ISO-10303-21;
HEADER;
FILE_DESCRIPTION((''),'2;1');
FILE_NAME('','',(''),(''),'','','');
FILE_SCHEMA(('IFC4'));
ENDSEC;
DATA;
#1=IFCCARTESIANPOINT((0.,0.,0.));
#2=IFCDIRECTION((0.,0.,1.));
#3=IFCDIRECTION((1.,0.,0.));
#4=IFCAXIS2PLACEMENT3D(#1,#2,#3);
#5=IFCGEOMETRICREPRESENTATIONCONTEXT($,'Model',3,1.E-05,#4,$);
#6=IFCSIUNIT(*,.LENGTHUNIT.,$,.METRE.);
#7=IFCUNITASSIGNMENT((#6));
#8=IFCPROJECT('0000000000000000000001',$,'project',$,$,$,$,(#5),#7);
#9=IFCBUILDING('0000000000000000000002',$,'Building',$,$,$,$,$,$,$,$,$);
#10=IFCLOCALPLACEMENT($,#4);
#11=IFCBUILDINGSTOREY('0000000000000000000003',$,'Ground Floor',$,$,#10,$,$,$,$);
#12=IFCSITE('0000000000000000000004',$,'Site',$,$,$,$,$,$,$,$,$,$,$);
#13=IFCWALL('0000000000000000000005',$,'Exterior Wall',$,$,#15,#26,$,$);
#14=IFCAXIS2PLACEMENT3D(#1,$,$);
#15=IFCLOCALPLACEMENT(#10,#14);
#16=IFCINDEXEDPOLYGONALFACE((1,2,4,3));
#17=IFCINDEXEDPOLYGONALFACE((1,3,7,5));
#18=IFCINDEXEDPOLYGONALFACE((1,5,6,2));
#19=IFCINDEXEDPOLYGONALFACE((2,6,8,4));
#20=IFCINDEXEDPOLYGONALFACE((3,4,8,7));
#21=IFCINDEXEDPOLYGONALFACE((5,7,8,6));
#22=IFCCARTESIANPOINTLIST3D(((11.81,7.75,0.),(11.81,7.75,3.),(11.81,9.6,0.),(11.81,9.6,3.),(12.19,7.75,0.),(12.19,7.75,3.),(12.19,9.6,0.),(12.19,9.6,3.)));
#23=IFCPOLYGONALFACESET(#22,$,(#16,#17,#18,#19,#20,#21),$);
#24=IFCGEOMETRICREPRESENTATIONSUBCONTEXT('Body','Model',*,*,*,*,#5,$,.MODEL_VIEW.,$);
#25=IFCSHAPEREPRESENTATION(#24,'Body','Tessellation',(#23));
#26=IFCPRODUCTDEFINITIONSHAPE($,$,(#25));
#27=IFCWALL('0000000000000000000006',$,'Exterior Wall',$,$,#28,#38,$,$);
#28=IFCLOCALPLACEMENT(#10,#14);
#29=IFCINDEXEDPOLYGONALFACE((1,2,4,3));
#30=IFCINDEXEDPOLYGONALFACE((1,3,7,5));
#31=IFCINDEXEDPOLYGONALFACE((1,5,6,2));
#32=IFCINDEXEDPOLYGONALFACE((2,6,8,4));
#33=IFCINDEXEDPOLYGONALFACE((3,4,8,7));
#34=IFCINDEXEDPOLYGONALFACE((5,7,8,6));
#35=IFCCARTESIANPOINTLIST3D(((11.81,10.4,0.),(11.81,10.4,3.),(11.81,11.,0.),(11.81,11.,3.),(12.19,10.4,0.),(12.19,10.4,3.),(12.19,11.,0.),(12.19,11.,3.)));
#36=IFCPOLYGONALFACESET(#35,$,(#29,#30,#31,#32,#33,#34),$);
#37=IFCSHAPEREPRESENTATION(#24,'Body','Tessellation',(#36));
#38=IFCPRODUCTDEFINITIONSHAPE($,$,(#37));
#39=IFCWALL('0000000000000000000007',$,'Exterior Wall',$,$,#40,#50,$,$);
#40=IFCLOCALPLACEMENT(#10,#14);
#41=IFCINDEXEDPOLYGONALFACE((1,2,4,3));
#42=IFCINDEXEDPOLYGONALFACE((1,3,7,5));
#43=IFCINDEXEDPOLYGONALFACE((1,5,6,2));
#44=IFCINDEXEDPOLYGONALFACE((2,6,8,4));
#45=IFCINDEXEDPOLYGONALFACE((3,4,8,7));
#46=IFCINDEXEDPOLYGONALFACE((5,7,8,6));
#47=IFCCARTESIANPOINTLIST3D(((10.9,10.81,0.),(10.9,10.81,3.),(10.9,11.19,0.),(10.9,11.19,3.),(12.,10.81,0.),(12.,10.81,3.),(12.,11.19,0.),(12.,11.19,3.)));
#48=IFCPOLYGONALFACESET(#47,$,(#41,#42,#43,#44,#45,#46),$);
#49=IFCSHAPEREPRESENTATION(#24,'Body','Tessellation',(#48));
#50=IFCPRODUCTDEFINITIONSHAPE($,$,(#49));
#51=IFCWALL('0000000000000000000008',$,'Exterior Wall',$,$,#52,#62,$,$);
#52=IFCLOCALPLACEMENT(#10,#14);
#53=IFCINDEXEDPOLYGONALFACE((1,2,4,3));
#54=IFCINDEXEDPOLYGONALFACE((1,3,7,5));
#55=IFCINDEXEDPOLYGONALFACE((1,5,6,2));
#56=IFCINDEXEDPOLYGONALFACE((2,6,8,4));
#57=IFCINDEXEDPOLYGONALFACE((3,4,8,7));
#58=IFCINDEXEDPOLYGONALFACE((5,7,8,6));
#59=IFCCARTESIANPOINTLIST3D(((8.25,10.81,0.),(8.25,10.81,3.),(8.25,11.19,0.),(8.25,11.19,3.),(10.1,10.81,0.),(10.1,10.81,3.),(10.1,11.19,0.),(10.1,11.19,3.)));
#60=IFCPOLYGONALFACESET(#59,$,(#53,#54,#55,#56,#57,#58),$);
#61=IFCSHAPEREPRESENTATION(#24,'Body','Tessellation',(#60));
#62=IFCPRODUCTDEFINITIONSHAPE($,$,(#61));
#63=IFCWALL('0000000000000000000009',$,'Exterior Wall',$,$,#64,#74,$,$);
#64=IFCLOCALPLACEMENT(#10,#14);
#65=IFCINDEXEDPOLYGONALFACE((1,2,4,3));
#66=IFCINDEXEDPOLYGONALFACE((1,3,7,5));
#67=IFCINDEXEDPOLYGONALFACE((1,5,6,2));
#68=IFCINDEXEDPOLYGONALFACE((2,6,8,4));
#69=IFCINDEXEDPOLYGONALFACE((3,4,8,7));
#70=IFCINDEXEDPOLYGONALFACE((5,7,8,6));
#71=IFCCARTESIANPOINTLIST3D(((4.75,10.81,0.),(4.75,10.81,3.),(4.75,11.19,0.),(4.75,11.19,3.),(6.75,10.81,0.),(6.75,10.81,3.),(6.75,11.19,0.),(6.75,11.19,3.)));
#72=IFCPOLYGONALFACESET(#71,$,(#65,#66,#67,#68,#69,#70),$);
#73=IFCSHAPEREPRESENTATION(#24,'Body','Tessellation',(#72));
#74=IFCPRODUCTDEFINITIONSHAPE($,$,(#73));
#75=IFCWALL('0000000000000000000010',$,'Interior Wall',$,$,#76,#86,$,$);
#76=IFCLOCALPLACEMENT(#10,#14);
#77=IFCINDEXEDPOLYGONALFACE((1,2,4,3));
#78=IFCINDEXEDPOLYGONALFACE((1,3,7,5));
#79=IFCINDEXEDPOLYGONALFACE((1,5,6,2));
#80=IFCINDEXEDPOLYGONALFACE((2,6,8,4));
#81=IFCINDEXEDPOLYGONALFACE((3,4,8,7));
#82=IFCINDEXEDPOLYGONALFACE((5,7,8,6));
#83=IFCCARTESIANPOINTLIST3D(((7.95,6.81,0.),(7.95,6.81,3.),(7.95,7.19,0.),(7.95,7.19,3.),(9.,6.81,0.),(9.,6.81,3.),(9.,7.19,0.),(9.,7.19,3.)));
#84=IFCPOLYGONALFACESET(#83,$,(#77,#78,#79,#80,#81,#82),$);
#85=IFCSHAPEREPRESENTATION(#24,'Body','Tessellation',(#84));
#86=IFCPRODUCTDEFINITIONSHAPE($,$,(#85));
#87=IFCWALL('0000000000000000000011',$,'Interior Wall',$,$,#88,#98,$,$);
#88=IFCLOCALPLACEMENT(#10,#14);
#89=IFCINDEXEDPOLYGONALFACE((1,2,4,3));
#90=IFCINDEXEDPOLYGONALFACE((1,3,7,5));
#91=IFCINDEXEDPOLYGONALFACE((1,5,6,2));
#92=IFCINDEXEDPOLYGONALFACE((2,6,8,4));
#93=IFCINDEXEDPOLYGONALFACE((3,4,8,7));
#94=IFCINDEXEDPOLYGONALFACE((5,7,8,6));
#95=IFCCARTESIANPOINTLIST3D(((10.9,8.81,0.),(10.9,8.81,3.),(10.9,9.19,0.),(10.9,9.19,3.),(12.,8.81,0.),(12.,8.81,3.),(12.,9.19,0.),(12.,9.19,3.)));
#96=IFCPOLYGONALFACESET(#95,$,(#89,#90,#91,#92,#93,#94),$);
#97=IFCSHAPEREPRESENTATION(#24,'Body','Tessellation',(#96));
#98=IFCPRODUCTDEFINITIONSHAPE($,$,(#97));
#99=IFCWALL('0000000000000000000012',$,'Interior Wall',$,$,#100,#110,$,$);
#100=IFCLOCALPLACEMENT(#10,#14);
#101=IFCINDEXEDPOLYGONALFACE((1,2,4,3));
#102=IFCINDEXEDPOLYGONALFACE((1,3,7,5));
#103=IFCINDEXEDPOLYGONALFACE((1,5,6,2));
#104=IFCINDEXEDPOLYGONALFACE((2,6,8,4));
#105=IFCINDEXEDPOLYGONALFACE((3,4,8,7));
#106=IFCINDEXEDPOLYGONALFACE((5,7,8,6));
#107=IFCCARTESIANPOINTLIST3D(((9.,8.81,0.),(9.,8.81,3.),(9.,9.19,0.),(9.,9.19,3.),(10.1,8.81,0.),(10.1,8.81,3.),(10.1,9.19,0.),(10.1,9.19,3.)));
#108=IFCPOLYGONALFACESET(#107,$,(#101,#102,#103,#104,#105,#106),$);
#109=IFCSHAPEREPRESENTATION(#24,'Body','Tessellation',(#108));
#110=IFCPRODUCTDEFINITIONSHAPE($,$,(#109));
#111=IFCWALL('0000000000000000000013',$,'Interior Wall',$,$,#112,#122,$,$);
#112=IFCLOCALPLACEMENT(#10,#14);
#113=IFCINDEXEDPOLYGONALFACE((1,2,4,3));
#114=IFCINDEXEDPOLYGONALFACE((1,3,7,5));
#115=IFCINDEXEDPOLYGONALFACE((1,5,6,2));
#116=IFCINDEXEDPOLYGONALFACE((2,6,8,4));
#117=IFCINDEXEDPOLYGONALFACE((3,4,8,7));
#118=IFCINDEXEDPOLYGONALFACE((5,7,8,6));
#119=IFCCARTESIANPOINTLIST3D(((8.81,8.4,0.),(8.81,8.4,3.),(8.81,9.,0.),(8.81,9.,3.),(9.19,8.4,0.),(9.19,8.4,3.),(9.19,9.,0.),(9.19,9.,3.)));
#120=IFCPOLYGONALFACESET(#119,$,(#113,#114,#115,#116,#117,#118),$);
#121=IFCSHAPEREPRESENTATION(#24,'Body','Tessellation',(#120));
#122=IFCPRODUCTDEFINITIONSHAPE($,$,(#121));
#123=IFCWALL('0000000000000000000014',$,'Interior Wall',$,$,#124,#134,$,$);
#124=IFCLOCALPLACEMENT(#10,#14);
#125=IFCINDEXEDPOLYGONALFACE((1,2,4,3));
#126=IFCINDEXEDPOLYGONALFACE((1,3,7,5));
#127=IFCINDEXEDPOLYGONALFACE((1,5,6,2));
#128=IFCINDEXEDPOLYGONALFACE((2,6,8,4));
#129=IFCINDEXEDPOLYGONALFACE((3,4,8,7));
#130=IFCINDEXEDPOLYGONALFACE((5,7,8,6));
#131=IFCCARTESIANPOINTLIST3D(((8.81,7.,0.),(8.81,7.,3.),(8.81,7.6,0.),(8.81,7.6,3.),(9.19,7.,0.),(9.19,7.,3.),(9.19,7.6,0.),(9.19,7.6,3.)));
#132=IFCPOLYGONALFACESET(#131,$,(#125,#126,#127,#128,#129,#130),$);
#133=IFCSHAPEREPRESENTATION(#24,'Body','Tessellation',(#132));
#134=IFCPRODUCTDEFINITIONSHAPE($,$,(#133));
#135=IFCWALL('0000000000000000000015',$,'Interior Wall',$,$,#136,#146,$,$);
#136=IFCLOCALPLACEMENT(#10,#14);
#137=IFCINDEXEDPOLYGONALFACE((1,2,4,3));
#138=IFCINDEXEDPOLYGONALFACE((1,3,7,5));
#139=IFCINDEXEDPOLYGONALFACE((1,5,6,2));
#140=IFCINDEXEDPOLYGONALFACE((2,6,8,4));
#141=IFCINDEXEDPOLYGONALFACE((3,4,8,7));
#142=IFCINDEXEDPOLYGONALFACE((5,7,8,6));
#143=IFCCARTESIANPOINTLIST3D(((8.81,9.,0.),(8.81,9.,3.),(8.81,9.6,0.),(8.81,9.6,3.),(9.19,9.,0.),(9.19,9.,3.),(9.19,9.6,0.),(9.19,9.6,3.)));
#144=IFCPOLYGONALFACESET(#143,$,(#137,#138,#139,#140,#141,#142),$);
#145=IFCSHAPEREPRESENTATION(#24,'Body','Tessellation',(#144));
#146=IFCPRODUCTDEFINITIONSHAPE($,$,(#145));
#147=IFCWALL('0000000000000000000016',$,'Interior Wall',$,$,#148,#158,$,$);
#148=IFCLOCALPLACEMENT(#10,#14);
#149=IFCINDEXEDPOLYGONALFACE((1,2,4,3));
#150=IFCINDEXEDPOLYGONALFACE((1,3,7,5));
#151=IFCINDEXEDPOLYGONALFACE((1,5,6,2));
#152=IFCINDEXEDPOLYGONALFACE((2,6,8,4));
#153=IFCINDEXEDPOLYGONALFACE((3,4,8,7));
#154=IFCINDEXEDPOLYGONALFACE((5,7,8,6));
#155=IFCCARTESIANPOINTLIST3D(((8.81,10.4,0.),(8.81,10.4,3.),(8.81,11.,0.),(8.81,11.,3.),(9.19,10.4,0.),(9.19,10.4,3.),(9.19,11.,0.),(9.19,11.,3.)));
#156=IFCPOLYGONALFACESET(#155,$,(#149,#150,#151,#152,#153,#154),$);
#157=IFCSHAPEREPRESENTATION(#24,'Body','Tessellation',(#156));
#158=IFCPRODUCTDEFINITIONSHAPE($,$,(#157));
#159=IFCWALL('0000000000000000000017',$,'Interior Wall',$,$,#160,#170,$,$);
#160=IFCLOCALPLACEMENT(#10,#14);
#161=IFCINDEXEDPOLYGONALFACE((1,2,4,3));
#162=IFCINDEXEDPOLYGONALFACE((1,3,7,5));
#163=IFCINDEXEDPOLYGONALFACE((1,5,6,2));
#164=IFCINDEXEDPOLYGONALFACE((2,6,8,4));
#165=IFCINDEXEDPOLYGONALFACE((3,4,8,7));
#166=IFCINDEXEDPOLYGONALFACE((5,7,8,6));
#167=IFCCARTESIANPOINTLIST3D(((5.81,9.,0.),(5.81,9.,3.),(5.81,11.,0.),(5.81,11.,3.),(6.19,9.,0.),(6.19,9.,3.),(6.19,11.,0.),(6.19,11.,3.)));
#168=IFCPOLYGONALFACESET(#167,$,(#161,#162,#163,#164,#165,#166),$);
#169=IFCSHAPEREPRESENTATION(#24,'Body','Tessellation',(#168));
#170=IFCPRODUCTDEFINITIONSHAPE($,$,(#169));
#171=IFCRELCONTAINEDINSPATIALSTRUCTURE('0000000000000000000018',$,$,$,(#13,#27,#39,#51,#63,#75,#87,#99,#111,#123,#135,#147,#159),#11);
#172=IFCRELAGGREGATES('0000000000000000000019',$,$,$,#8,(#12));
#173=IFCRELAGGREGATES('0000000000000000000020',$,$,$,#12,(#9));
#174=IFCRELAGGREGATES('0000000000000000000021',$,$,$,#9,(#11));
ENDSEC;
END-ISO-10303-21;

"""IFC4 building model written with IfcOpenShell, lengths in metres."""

from ifc_helpers import new_model, si_unit, frame, origin_with_axes, place, context, subcontext, project, spatial, indexed_curve, outline, extrude, element, save


model = new_model("IFC4")

# Units and contexts
model_context = context("Model", 3, precision=1e-05, world=origin_with_axes())
body_context = subcontext(model_context, "Body", "Model", "MODEL_VIEW")
ifc_project = project(units=[si_unit("LENGTHUNIT", "METRE")], contexts=[model_context])

# Site, building, storey
site = spatial("IfcSite", under=ifc_project, Name="Site")
building = spatial("IfcBuilding", under=site, Name="Building")
storey_placement = place(None, origin_with_axes())
storey = spatial("IfcBuildingStorey", under=building, at=storey_placement, Name="Ground Floor")

# Walls
wall_1_placement = place(storey_placement, frame((12.0, 7.75, 0.0), z_axis=(0.0, 0.0, 1.0), x_axis=(0.0, 1.0, 0.0)))
element("IfcWall", 1, at=wall_1_placement, inside=storey, Name="Exterior Wall", context=body_context, shape_type="SweptSolid", body=[
    extrude(outline(indexed_curve([(0.0, 0.0), (0.0, 0.38), (1.85, 0.38), (1.85, 0.0), (0.0, 0.0)], self_intersect=False)), frame((0.0, -0.19, 0.0), z_axis=(0.0, 0.0, 1.0), x_axis=(1.0, 0.0, 0.0)), (0.0, 0.0, 1.0), 3.0),
])
wall_2_placement = place(storey_placement, frame((12.0, 10.4, 0.0), z_axis=(0.0, 0.0, 1.0), x_axis=(0.0, 1.0, 0.0)))
element("IfcWall", 2, at=wall_2_placement, inside=storey, Name="Exterior Wall", context=body_context, shape_type="SweptSolid", body=[
    extrude(outline(indexed_curve([(0.0, 0.0), (0.0, 0.38), (0.6, 0.38), (0.6, 0.0), (0.0, 0.0)], self_intersect=False)), frame((0.0, -0.19, 0.0), z_axis=(0.0, 0.0, 1.0), x_axis=(1.0, 0.0, 0.0)), (0.0, 0.0, 1.0), 3.0),
])
wall_3_placement = place(storey_placement, frame((12.0, 11.0, 0.0), z_axis=(0.0, 0.0, 1.0), x_axis=(-1.0, 0.0, 0.0)))
element("IfcWall", 3, at=wall_3_placement, inside=storey, Name="Exterior Wall", context=body_context, shape_type="SweptSolid", body=[
    extrude(outline(indexed_curve([(0.0, 0.0), (0.0, 0.38), (1.1, 0.38), (1.1, 0.0), (0.0, 0.0)], self_intersect=False)), frame((0.0, -0.19, 0.0), z_axis=(0.0, 0.0, 1.0), x_axis=(1.0, 0.0, 0.0)), (0.0, 0.0, 1.0), 3.0),
])
wall_4_placement = place(storey_placement, frame((10.1, 11.0, 0.0), z_axis=(0.0, 0.0, 1.0), x_axis=(-1.0, 0.0, 0.0)))
element("IfcWall", 4, at=wall_4_placement, inside=storey, Name="Exterior Wall", context=body_context, shape_type="SweptSolid", body=[
    extrude(outline(indexed_curve([(0.0, 0.0), (0.0, 0.38), (1.85, 0.38), (1.85, 0.0), (0.0, 0.0)], self_intersect=False)), frame((0.0, -0.19, 0.0), z_axis=(0.0, 0.0, 1.0), x_axis=(1.0, 0.0, 0.0)), (0.0, 0.0, 1.0), 3.0),
])
wall_5_placement = place(storey_placement, frame((6.75, 11.0, 0.0), z_axis=(0.0, 0.0, 1.0), x_axis=(-1.0, 0.0, 0.0)))
element("IfcWall", 5, at=wall_5_placement, inside=storey, Name="Exterior Wall", context=body_context, shape_type="SweptSolid", body=[
    extrude(outline(indexed_curve([(0.0, 0.0), (0.0, 0.38), (2.0, 0.38), (2.0, 0.0), (0.0, 0.0)], self_intersect=False)), frame((0.0, -0.19, 0.0), z_axis=(0.0, 0.0, 1.0), x_axis=(1.0, 0.0, 0.0)), (0.0, 0.0, 1.0), 3.0),
])
wall_6_placement = place(storey_placement, frame((9.0, 7.0, 0.0), z_axis=(0.0, 0.0, 1.0), x_axis=(-1.0, 0.0, 0.0)))
element("IfcWall", 6, at=wall_6_placement, inside=storey, Name="Interior Wall", context=body_context, shape_type="SweptSolid", body=[
    extrude(outline(indexed_curve([(0.0, 0.0), (0.0, 0.38), (1.05, 0.38), (1.05, 0.0), (0.0, 0.0)], self_intersect=False)), frame((0.0, -0.19, 0.0), z_axis=(0.0, 0.0, 1.0), x_axis=(1.0, 0.0, 0.0)), (0.0, 0.0, 1.0), 3.0),
])
for number, where, z_axis, x_axis, name in (
    (7, (12.0, 9.0, 0.0), (0.0, 0.0, 1.0), (-1.0, 0.0, 0.0), "Interior Wall"),
    (8, (10.1, 9.0, 0.0), (0.0, 0.0, 1.0), (-1.0, 0.0, 0.0), "Interior Wall"),
):
    element("IfcWall", number, at=place(storey_placement, frame(where, z_axis=z_axis, x_axis=x_axis)), inside=storey, Name=name, context=body_context, shape_type="SweptSolid", body=[
        extrude(outline(indexed_curve([(0.0, 0.0), (0.0, 0.38), (1.1, 0.38), (1.1, 0.0), (0.0, 0.0)], self_intersect=False)), frame((0.0, -0.19, 0.0), z_axis=(0.0, 0.0, 1.0), x_axis=(1.0, 0.0, 0.0)), (0.0, 0.0, 1.0), 3.0),
    ])
for number, where, z_axis, x_axis, name in (
    (9, (9.0, 9.0, 0.0), (0.0, 0.0, 1.0), (0.0, -1.0, 0.0), "Interior Wall"),
    (10, (9.0, 7.6, 0.0), (0.0, 0.0, 1.0), (0.0, -1.0, 0.0), "Interior Wall"),
    (11, (9.0, 9.0, 0.0), (0.0, 0.0, 1.0), (0.0, 1.0, 0.0), "Interior Wall"),
    (12, (9.0, 10.4, 0.0), (0.0, 0.0, 1.0), (0.0, 1.0, 0.0), "Interior Wall"),
):
    element("IfcWall", number, at=place(storey_placement, frame(where, z_axis=z_axis, x_axis=x_axis)), inside=storey, Name=name, context=body_context, shape_type="SweptSolid", body=[
        extrude(outline(indexed_curve([(0.0, 0.0), (0.0, 0.38), (0.6, 0.38), (0.6, 0.0), (0.0, 0.0)], self_intersect=False)), frame((0.0, -0.19, 0.0), z_axis=(0.0, 0.0, 1.0), x_axis=(1.0, 0.0, 0.0)), (0.0, 0.0, 1.0), 3.0),
    ])
wall_7_placement = place(storey_placement, frame((6.0, 11.0, 0.0), z_axis=(0.0, 0.0, 1.0), x_axis=(0.0, -1.0, 0.0)))
element("IfcWall", 13, at=wall_7_placement, inside=storey, Name="Interior Wall", context=body_context, shape_type="SweptSolid", body=[
    extrude(outline(indexed_curve([(0.0, 0.0), (0.0, 0.38), (2.0, 0.38), (2.0, 0.0), (0.0, 0.0)], self_intersect=False)), frame((0.0, -0.19, 0.0), z_axis=(0.0, 0.0, 1.0), x_axis=(1.0, 0.0, 0.0)), (0.0, 0.0, 1.0), 3.0),
])

save(model, "model.ifc")
